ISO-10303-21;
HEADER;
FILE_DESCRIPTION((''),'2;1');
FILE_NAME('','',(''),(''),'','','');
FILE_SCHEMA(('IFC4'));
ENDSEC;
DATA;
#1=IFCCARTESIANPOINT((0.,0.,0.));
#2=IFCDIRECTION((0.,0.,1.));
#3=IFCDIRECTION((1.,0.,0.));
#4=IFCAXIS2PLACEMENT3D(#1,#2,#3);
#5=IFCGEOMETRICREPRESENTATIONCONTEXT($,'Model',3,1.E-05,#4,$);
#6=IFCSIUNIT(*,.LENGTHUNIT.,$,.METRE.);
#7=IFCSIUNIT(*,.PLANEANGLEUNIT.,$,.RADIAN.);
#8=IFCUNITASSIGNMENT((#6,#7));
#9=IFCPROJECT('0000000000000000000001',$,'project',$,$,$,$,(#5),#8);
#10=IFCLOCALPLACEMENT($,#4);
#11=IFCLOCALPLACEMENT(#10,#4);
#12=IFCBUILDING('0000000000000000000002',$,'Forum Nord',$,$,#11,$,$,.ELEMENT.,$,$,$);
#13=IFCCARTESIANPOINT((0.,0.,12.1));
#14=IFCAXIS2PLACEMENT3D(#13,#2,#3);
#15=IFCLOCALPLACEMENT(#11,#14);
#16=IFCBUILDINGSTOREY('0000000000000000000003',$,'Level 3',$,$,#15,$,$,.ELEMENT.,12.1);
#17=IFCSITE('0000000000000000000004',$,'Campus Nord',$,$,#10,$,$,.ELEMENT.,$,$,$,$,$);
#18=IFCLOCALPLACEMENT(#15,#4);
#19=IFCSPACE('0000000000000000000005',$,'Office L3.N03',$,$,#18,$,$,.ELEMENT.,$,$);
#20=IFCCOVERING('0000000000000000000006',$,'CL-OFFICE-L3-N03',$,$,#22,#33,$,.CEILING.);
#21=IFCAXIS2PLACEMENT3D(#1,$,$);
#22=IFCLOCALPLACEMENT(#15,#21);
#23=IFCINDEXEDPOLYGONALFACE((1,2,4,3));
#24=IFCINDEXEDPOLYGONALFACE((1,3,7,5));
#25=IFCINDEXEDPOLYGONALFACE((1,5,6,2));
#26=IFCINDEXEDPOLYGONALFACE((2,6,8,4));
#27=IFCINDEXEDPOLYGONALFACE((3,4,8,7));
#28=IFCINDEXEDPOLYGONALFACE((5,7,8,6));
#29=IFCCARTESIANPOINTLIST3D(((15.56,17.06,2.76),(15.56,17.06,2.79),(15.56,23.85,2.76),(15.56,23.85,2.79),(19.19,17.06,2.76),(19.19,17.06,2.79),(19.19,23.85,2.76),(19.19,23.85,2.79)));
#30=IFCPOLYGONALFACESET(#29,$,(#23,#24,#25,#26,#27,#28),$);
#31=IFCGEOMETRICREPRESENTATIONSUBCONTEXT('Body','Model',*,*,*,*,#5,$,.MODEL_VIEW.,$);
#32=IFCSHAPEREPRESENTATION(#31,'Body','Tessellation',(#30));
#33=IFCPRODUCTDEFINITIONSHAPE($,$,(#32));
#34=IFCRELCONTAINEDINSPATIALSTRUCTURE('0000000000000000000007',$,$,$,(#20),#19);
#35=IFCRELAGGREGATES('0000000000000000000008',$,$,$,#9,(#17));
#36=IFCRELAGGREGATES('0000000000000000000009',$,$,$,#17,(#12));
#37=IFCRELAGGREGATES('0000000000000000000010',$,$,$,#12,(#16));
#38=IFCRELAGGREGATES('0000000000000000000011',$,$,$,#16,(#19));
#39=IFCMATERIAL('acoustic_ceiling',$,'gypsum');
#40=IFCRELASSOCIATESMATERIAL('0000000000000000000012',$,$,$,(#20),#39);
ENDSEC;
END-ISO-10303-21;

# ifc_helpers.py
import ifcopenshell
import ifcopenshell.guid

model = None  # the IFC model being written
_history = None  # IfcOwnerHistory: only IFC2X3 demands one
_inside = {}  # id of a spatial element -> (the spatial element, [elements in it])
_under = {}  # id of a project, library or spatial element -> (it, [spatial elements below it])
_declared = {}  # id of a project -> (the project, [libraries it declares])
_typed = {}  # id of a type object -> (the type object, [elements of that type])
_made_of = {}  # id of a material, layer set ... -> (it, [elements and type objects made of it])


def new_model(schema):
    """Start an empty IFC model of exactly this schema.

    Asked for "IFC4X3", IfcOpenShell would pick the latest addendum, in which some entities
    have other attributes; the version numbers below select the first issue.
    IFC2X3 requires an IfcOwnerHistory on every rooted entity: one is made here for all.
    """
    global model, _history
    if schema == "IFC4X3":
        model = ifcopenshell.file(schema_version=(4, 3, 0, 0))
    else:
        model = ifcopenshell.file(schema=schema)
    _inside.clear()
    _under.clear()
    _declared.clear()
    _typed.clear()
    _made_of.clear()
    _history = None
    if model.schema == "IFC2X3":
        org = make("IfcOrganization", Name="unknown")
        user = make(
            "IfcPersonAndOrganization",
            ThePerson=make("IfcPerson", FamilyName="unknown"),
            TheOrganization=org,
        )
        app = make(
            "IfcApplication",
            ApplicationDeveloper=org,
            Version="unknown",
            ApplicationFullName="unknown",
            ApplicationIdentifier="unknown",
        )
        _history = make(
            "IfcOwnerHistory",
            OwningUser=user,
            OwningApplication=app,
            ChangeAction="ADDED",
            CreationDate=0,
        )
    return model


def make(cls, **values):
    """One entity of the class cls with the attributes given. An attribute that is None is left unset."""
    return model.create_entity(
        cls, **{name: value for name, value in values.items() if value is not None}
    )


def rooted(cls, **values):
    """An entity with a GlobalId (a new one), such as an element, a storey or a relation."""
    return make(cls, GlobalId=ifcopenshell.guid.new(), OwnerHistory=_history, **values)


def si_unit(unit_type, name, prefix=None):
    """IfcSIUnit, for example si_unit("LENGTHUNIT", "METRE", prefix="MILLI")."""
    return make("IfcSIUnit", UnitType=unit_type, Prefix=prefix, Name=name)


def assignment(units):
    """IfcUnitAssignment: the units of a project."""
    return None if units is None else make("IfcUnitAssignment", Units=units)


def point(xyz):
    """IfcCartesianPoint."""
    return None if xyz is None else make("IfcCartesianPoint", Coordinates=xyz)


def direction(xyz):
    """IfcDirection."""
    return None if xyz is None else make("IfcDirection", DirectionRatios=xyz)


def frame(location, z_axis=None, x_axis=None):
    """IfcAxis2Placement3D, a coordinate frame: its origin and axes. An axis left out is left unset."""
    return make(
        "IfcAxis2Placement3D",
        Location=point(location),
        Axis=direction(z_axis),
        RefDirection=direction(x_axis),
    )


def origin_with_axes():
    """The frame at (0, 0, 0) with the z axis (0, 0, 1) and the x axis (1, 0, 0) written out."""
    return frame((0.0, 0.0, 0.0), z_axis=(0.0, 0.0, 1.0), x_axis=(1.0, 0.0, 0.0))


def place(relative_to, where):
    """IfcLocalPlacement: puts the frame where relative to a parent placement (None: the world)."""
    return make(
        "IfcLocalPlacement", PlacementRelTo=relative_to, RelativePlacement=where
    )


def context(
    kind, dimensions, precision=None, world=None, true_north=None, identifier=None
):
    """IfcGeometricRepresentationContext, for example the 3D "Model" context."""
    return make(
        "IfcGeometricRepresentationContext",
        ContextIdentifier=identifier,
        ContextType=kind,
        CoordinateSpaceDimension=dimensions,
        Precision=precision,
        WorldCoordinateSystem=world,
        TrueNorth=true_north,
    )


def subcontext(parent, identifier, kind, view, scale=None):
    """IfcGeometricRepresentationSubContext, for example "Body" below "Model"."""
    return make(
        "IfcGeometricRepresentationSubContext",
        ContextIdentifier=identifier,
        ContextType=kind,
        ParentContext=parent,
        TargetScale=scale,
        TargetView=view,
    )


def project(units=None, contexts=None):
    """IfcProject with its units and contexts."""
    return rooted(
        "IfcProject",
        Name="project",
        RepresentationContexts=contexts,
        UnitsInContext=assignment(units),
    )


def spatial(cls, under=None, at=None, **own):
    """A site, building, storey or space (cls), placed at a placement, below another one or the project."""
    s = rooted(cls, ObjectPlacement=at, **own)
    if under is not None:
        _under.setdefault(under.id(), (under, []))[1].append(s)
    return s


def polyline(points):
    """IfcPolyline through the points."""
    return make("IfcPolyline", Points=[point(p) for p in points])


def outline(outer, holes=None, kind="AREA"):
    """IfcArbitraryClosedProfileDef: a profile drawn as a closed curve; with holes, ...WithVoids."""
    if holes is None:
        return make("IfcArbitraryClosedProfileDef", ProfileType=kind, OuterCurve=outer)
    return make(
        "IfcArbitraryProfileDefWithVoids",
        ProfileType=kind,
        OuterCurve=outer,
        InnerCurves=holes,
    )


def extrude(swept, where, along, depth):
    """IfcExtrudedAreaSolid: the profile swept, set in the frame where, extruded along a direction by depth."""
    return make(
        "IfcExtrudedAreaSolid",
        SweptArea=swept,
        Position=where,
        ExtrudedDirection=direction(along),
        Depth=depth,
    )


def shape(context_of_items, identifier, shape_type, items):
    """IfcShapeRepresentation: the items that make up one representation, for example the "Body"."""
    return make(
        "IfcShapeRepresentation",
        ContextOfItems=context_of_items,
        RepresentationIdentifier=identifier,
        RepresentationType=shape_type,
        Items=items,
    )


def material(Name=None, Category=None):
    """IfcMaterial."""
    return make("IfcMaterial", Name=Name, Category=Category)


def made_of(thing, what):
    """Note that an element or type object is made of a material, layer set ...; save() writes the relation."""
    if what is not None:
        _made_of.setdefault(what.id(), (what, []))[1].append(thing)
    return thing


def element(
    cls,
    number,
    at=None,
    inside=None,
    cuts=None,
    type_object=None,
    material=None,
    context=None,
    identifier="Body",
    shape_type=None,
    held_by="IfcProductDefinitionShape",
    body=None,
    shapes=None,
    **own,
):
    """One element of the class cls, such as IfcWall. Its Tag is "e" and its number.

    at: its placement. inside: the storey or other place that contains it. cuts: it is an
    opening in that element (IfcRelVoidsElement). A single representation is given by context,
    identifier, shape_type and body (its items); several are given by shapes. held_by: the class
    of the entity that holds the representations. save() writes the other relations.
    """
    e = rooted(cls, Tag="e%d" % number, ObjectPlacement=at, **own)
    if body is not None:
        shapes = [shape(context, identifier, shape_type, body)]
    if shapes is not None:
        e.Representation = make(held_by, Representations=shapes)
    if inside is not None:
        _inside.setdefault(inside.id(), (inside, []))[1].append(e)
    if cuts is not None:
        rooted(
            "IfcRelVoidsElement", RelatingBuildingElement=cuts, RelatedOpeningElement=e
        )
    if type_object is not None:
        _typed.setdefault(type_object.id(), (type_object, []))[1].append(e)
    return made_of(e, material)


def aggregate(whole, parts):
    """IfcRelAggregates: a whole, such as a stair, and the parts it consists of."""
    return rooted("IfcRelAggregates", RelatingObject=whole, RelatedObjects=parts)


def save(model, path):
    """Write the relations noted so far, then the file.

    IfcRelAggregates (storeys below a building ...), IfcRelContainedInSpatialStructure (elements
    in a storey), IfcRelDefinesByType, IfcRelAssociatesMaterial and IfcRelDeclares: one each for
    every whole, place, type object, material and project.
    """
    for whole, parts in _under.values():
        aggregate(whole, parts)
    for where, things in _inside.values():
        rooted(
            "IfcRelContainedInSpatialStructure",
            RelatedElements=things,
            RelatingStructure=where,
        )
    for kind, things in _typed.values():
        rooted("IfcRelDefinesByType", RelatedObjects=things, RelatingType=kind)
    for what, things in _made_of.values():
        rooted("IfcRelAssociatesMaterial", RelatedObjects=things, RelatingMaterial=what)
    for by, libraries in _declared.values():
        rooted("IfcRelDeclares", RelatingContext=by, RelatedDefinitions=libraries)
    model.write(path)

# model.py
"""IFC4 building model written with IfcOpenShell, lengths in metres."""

from ifc_helpers import new_model, si_unit, frame, origin_with_axes, place, context, subcontext, project, spatial, polyline, outline, extrude, material, element, save


model = new_model("IFC4")

# Units and contexts
model_context = context("Model", 3, precision=1e-05, world=origin_with_axes())
body_context = subcontext(model_context, "Body", "Model", "MODEL_VIEW")
ifc_project = project(units=[si_unit("LENGTHUNIT", "METRE"), si_unit("PLANEANGLEUNIT", "RADIAN")], contexts=[model_context])

# Site, building, storey
site_placement = place(None, origin_with_axes())
site = spatial("IfcSite", under=ifc_project, at=site_placement, Name="Campus Nord", CompositionType="ELEMENT")
building_placement = place(site_placement, origin_with_axes())
building = spatial("IfcBuilding", under=site, at=building_placement, Name="Forum Nord", CompositionType="ELEMENT")
storey_placement = place(building_placement, frame((0.0, 0.0, 12.1), z_axis=(0.0, 0.0, 1.0), x_axis=(1.0, 0.0, 0.0)))
storey = spatial("IfcBuildingStorey", under=building, at=storey_placement, Name="Level 3", CompositionType="ELEMENT", Elevation=12.1)

# Shared definitions
ifc_material = material(Name="acoustic_ceiling", Category="gypsum")

# Shared definitions
space_1_placement = place(storey_placement, origin_with_axes())
space_1 = spatial("IfcSpace", under=storey, at=space_1_placement, Name="Office L3.N03", CompositionType="ELEMENT")

# Covering
covering_1_placement = place(storey_placement, frame((0.0, 0.0, 2.76), z_axis=(0.0, 0.0, 1.0), x_axis=(1.0, 0.0, 0.0)))
element("IfcCovering", 1, at=covering_1_placement, inside=space_1, material=ifc_material, Name="CL-OFFICE-L3-N03", PredefinedType="CEILING", context=body_context, shape_type="SweptSolid", body=[
    extrude(outline(polyline([(15.56, 23.85), (15.56, 17.06), (19.19, 17.06), (19.19, 23.85), (15.56, 23.85)])), origin_with_axes(), (0.0, 0.0, 1.0), 0.03),
])

save(model, "model.ifc")
